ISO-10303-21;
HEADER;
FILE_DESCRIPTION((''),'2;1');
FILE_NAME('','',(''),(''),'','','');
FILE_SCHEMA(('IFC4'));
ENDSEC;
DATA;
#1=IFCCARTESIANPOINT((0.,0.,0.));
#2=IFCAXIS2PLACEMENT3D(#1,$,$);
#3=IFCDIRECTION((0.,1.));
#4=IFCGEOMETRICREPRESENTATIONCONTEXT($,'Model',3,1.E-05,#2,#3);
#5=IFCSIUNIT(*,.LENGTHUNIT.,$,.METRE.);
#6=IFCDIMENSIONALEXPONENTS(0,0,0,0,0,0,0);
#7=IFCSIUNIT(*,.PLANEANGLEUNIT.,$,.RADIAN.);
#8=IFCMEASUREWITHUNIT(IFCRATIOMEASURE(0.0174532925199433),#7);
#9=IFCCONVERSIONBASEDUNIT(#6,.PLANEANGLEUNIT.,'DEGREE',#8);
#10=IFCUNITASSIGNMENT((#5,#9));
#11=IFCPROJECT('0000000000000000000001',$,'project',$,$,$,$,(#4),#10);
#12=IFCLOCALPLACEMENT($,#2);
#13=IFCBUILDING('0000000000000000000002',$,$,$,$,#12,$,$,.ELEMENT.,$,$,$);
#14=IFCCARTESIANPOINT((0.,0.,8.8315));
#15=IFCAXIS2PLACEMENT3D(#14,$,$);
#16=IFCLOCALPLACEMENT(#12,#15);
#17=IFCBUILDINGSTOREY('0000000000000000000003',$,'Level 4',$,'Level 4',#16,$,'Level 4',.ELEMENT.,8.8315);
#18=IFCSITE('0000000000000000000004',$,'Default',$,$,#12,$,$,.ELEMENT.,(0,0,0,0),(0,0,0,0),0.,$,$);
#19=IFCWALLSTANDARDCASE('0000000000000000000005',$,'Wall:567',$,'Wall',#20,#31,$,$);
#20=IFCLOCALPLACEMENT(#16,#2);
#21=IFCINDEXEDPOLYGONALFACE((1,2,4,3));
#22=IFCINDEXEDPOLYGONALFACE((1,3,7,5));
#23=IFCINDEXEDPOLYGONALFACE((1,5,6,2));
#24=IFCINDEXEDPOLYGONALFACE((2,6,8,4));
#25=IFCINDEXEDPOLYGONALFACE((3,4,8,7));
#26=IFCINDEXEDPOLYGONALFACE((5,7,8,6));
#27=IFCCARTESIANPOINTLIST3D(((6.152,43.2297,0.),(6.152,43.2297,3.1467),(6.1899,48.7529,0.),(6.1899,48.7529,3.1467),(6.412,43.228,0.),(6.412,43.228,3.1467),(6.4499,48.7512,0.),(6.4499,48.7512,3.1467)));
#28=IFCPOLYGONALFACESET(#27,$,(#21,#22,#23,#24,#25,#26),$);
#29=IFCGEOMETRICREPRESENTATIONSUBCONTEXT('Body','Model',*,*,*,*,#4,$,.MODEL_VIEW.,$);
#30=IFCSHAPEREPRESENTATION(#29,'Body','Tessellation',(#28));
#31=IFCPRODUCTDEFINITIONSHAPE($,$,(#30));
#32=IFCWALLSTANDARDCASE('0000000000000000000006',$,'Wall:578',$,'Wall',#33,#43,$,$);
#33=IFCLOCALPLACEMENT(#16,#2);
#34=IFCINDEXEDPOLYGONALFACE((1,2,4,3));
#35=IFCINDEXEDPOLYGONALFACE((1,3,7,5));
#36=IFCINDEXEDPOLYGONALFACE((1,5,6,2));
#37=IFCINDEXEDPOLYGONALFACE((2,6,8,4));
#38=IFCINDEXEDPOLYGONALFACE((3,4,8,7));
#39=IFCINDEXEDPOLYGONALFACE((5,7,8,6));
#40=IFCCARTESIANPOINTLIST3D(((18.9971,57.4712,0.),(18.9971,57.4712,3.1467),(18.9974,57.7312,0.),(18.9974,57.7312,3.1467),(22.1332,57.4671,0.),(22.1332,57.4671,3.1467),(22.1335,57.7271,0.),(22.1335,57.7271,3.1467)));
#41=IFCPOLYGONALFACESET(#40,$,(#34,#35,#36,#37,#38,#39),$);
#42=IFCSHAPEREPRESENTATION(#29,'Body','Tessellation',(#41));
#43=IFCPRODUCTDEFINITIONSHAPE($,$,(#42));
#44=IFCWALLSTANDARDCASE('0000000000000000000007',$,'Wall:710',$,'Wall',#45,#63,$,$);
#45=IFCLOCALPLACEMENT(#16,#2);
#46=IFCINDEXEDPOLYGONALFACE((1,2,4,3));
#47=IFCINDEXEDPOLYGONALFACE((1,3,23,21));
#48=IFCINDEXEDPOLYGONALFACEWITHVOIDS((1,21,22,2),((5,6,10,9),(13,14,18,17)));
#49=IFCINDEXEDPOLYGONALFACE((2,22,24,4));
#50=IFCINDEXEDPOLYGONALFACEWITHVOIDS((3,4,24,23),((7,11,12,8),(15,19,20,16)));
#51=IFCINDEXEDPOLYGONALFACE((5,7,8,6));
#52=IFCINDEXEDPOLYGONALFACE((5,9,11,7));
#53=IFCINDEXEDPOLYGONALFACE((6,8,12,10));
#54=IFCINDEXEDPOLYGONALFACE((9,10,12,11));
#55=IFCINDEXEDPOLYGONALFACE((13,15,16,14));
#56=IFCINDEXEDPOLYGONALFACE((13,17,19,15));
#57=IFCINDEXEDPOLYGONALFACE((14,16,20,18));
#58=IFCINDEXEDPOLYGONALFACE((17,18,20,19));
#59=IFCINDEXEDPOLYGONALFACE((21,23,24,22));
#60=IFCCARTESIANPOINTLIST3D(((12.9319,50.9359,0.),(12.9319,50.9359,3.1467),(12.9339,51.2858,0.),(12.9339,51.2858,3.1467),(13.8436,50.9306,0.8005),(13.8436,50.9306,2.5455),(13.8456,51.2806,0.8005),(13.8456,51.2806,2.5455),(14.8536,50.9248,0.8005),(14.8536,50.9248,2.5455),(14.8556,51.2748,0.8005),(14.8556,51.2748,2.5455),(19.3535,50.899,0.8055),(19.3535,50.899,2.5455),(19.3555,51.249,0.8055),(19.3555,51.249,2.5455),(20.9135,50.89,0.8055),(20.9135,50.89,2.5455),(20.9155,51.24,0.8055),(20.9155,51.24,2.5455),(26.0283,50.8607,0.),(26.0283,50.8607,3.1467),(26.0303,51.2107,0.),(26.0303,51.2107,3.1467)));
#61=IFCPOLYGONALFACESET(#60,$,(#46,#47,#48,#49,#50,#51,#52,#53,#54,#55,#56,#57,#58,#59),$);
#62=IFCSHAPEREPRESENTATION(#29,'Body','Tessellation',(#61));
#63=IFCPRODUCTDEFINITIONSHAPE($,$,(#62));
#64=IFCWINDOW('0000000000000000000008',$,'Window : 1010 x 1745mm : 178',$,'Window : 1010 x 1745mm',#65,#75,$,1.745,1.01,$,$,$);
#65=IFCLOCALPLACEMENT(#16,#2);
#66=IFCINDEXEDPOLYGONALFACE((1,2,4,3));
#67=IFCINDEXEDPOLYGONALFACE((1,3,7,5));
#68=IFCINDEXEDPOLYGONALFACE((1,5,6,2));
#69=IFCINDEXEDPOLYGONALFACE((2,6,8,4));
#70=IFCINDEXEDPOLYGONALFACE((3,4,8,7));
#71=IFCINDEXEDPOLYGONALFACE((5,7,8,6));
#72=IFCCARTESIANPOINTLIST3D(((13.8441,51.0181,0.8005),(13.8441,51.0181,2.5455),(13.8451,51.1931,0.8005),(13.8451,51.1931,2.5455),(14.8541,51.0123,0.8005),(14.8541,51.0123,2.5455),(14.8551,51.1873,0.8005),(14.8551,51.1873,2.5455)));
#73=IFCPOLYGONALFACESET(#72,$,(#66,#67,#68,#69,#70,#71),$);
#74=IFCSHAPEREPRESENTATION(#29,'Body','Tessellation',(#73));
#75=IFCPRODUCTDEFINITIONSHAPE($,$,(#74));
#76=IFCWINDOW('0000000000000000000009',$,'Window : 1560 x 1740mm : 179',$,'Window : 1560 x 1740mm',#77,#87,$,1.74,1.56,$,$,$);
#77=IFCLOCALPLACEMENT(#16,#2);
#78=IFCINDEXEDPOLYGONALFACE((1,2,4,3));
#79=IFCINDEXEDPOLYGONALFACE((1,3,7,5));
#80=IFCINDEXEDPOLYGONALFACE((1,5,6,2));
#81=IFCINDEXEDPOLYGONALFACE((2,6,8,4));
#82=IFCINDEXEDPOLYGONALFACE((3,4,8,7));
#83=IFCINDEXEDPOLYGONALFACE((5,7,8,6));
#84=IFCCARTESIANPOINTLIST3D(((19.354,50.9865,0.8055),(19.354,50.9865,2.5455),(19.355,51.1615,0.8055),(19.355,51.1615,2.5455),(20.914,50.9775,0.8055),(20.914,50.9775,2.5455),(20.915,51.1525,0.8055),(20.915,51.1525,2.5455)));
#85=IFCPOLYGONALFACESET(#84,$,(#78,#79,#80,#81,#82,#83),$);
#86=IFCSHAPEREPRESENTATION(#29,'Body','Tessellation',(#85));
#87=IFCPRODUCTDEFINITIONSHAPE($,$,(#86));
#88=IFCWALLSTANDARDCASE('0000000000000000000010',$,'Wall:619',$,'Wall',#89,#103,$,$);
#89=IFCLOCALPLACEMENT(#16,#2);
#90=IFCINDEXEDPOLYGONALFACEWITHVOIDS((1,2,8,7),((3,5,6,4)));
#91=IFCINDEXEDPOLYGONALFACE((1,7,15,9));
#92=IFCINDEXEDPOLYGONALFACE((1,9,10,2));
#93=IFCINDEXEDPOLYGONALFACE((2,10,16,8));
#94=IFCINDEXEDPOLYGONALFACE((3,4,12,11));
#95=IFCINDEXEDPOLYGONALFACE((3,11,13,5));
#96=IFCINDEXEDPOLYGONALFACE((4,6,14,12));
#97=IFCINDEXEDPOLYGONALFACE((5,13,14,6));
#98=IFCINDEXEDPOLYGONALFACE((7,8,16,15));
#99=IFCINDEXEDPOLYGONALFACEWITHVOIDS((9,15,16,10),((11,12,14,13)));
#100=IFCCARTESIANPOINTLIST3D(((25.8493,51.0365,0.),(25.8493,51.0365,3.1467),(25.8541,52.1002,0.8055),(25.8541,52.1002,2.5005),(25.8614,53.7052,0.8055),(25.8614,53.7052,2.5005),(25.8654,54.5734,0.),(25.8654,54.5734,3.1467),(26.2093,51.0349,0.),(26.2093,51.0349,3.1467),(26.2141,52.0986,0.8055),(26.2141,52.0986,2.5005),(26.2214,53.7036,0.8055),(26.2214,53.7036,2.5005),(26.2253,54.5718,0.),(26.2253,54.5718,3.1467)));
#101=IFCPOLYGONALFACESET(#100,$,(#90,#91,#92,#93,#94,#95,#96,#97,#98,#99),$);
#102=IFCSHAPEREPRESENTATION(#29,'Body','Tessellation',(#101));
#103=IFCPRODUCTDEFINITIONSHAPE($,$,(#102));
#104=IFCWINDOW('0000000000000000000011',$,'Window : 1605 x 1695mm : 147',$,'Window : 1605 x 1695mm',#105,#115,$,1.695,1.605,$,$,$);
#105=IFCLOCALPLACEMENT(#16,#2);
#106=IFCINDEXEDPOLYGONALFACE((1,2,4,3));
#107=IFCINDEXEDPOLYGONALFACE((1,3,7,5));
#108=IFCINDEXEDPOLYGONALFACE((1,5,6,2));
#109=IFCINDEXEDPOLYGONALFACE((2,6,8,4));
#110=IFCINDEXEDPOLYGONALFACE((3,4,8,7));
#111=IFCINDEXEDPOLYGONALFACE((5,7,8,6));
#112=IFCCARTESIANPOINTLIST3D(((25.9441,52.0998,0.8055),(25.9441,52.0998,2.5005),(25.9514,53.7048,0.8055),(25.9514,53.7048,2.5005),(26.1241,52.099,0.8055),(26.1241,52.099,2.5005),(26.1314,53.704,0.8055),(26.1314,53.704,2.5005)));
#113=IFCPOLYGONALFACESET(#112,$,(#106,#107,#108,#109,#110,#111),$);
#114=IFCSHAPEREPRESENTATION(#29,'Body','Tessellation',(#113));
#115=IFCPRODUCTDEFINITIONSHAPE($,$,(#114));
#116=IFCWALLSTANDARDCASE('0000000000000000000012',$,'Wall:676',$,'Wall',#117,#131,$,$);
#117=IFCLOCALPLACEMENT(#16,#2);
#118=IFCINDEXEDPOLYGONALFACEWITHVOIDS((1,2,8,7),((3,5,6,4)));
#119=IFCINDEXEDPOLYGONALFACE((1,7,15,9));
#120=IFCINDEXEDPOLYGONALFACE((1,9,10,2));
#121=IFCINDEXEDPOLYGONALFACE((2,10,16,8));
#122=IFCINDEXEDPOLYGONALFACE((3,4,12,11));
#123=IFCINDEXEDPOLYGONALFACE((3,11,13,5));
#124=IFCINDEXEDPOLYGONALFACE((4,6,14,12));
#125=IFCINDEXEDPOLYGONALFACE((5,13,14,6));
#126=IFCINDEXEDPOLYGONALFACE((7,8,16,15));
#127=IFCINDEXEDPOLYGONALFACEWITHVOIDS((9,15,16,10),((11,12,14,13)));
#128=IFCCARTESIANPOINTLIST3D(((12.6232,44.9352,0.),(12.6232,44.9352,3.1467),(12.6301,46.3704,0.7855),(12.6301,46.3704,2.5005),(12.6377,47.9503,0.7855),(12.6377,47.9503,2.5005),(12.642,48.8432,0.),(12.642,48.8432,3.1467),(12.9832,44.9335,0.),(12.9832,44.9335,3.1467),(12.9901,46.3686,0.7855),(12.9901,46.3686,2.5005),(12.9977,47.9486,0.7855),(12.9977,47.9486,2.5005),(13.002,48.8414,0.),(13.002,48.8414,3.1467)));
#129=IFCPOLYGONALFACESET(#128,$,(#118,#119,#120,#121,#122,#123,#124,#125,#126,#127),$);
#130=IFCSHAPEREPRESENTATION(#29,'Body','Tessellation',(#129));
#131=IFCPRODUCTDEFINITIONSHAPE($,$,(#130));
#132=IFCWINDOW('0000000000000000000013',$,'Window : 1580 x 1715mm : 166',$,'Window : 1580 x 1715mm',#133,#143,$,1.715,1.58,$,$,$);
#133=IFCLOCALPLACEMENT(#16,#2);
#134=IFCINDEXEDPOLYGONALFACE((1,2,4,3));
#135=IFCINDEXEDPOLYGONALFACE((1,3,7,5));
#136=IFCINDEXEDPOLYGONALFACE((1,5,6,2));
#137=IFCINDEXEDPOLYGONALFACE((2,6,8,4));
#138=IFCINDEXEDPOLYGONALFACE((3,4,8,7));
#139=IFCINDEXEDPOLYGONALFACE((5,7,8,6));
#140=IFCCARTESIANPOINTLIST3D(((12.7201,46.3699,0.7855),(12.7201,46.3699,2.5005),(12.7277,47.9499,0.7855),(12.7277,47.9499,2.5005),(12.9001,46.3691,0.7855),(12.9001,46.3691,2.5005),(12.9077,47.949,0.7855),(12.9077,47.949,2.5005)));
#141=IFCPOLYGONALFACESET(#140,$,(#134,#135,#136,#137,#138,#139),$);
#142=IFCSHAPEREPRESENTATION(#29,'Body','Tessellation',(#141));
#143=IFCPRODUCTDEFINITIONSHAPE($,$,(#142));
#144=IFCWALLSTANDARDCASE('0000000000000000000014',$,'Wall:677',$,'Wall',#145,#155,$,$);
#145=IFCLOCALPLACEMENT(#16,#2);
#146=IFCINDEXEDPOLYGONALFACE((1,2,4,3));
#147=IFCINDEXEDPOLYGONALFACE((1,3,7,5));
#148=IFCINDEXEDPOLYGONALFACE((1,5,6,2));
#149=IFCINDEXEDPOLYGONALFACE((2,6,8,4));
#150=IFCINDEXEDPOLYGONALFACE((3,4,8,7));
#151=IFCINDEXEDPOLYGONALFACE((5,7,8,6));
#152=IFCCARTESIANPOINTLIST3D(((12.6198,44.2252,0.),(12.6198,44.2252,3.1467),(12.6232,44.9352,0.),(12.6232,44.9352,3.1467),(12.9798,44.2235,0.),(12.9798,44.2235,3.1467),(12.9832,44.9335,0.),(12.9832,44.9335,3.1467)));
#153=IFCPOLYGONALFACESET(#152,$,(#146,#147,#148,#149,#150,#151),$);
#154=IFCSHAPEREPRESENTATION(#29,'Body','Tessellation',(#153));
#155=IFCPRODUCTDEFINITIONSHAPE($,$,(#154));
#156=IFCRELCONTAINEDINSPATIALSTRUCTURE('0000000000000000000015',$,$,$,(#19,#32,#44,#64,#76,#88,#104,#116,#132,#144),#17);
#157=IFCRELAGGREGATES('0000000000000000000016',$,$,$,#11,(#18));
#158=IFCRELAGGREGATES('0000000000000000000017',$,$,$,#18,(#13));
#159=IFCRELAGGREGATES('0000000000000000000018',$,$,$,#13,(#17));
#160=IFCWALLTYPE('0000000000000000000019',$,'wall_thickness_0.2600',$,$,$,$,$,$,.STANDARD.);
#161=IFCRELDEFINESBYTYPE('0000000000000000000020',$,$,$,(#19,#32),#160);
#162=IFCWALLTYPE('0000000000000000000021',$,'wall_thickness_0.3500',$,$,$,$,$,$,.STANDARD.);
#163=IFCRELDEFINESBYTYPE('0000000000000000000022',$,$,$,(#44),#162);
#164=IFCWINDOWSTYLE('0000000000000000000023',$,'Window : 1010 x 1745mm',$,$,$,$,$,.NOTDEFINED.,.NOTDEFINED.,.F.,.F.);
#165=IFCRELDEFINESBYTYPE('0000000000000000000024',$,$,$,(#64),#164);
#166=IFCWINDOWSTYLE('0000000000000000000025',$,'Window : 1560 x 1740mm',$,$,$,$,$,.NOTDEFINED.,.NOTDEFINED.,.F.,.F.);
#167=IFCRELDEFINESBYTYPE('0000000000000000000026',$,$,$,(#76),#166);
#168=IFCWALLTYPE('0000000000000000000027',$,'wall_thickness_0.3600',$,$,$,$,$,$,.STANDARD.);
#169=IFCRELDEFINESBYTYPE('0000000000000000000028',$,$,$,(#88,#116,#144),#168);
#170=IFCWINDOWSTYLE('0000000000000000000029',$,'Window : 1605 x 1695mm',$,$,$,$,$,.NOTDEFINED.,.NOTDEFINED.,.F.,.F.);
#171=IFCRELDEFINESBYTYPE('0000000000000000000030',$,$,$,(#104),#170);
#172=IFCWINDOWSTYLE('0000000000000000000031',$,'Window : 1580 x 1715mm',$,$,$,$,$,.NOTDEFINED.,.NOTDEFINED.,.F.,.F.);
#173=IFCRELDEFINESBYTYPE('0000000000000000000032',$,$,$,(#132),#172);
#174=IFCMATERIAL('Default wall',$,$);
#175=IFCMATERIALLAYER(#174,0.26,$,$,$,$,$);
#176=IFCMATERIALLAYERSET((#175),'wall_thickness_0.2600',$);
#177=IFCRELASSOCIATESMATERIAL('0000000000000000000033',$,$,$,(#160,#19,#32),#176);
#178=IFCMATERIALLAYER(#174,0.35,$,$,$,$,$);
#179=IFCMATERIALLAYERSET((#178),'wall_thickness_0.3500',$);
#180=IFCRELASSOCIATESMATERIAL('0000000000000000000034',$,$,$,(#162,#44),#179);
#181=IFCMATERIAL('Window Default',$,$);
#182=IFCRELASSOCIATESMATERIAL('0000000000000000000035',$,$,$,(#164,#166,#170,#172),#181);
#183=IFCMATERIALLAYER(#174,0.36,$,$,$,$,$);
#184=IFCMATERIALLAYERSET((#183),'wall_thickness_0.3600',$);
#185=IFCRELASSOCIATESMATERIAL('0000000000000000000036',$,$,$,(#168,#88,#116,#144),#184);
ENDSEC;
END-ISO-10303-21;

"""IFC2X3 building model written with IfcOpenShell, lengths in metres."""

from ifc_helpers import new_model, entity, si_unit, converted_unit, direction, frame, frame_2d, origin, origin_2d_with_axis, place, context, subcontext, project, spatial, polyline, rectangle, outline, extrude, source, transform, mapped, material, layer, layer_set, layer_usage, type_object, type_shapes, element, fill, save


model = new_model("IFC2X3")

# Units and contexts
model_context = context("Model", 3, precision=1e-05, world=origin(), true_north=direction((0.0, 1.0)))
body_context = subcontext(model_context, "Body", "Model", "MODEL_VIEW")
ifc_project = project(units=[si_unit("LENGTHUNIT", "METRE"), converted_unit("PLANEANGLEUNIT", "DEGREE", entity("IfcRatioMeasure", 0.0174532925199433), si_unit("PLANEANGLEUNIT", "RADIAN"), dimensions=[0, 0, 0, 0, 0, 0, 0])], contexts=[model_context])

# Site, building, storey
placement_1 = place(None, origin())
site = spatial("IfcSite", under=ifc_project, at=placement_1, Name="Default", CompositionType="ELEMENT", RefLatitude=(0, 0, 0, 0), RefLongitude=(0, 0, 0, 0), RefElevation=0.0)
building = spatial("IfcBuilding", under=site, at=placement_1, CompositionType="ELEMENT")
storey_placement = place(placement_1, frame((0.0, 0.0, 8.8315)))
storey = spatial("IfcBuildingStorey", under=building, at=storey_placement, Name="Level 4", ObjectType="Level 4", LongName="Level 4", CompositionType="ELEMENT", Elevation=8.8315)

# Walls
ifc_material_1 = material(Name="Default wall")
ifc_layer_1 = layer(ifc_material_1, 0.26)
ifc_layer_set_1 = layer_set([ifc_layer_1], Name="wall_thickness_0.2600")
ifc_layer_usage_1 = layer_usage(ifc_layer_set_1, "AXIS2", "POSITIVE", -0.13)
wall_type_1 = type_object("IfcWallType", Name="wall_thickness_0.2600", PredefinedType="STANDARD", material=ifc_layer_set_1)
wall_1_placement = place(storey_placement, frame((6.3199, 48.7521, 0.0), z_axis=(0.0, 0.0, 1.0), x_axis=(-0.006862, -0.999976, 0.0)))
element("IfcWallStandardCase", 1, at=wall_1_placement, inside=storey, type_object=wall_type_1, material=ifc_layer_usage_1, Name="Wall:567", ObjectType="Wall", context=body_context, shape_type="SweptSolid", body=[
    extrude(outline(polyline([(5.5233, -0.13), (5.5233, 0.13), (0.0, 0.13), (0.0, -0.13), (5.5233, -0.13)])), origin(), (0.0, 0.0, 1.0), 3.1467),
])
wall_2_placement = place(storey_placement, frame((18.9973, 57.6012, 0.0), z_axis=(0.0, 0.0, 1.0), x_axis=(0.999999, -0.001299, 0.0)))
element("IfcWallStandardCase", 2, at=wall_2_placement, inside=storey, type_object=wall_type_1, material=ifc_layer_usage_1, Name="Wall:578", ObjectType="Wall", context=body_context, shape_type="SweptSolid", body=[
    extrude(outline(polyline([(3.1361, -0.13), (3.1361, 0.13), (0.0, 0.13), (0.0, -0.13), (3.1361, -0.13)])), origin(), (0.0, 0.0, 1.0), 3.1467),
])

# Wall, openings, windows
ifc_layer_2 = layer(ifc_material_1, 0.35)
ifc_layer_set_2 = layer_set([ifc_layer_2], Name="wall_thickness_0.3500")
ifc_layer_usage_2 = layer_usage(ifc_layer_set_2, "AXIS2", "POSITIVE", -0.175)
wall_type_2 = type_object("IfcWallType", Name="wall_thickness_0.3500", PredefinedType="STANDARD", material=ifc_layer_set_2)
wall_3_placement = place(storey_placement, frame((12.9329, 51.1108, 0.0), z_axis=(0.0, 0.0, 1.0), x_axis=(0.999984, -0.00574, 0.0)))
wall_3 = element("IfcWallStandardCase", 3, at=wall_3_placement, inside=storey, type_object=wall_type_2, material=ifc_layer_usage_2, Name="Wall:710", ObjectType="Wall", context=body_context, shape_type="SweptSolid", body=[
    extrude(outline(polyline([(13.0966, -0.175), (13.0966, 0.175), (0.0, 0.175), (0.0, -0.175), (13.0966, -0.175)])), origin(), (0.0, 0.0, 1.0), 3.1467),
])
opening_1_placement = place(wall_3_placement, frame((0.9117, -0.175, 0.8005)))
opening_1 = element("IfcOpeningElement", 4, at=opening_1_placement, cuts=wall_3, ObjectType="Opening", context=body_context, shape_type="SweptSolid", body=[
    extrude(rectangle(XDim=1.01, YDim=1.745, at=frame_2d((0.8725, 0.505), x_axis=(0.0, 1.0))), frame((0.0, 0.0, 0.0), z_axis=(0.0, 1.0, 0.0), x_axis=(0.0, 0.0, 1.0)), (0.0, 0.0, 1.0), 0.35),
])
opening_2_placement = place(wall_3_placement, frame((6.4217, -0.175, 0.8055)))
opening_2 = element("IfcOpeningElement", 5, at=opening_2_placement, cuts=wall_3, ObjectType="Opening", context=body_context, shape_type="SweptSolid", body=[
    extrude(rectangle(XDim=1.56, YDim=1.74, at=frame_2d((0.87, 0.78), x_axis=(0.0, 1.0))), frame((0.0, 0.0, 0.0), z_axis=(0.0, 1.0, 0.0), x_axis=(0.0, 0.0, 1.0)), (0.0, 0.0, 1.0), 0.35),
])
ifc_material_2 = material(Name="Window Default")
window_style_1 = type_object("IfcWindowStyle", Name="Window : 1010 x 1745mm", ConstructionType="NOTDEFINED", OperationType="NOTDEFINED", ParameterTakesPrecedence=False, Sizeable=False, material=ifc_material_2)
shared_shape_1 = source(origin(), body_context, "Body", "SweptSolid", [
    extrude(rectangle(XDim=0.175, YDim=1.01, at=origin_2d_with_axis()), frame((0.505, 0.175, 0.0), z_axis=(0.0, 0.0, 1.0), x_axis=(0.0, 1.0, 0.0)), (0.0, 0.0, 1.0), 1.745),
])
type_shapes(window_style_1, [shared_shape_1])
window_1_placement = place(opening_1_placement, origin())
window_1 = element("IfcWindow", 6, at=window_1_placement, inside=storey, type_object=window_style_1, Name="Window : 1010 x 1745mm : 178", ObjectType="Window : 1010 x 1745mm", OverallHeight=1.745, OverallWidth=1.01, context=body_context, shape_type="MappedRepresentation", body=[
    mapped(shared_shape_1, transform((0.0, 0.0, 0.0), scale=1.0)),
])
fill(opening_1, window_1)
window_style_2 = type_object("IfcWindowStyle", Name="Window : 1560 x 1740mm", ConstructionType="NOTDEFINED", OperationType="NOTDEFINED", ParameterTakesPrecedence=False, Sizeable=False, material=ifc_material_2)
shared_shape_2 = source(origin(), body_context, "Body", "SweptSolid", [
    extrude(rectangle(XDim=0.175, YDim=1.56, at=origin_2d_with_axis()), frame((0.78, 0.175, 0.0), z_axis=(0.0, 0.0, 1.0), x_axis=(0.0, 1.0, 0.0)), (0.0, 0.0, 1.0), 1.74),
])
type_shapes(window_style_2, [shared_shape_2])
window_2_placement = place(opening_2_placement, origin())
window_2 = element("IfcWindow", 7, at=window_2_placement, inside=storey, type_object=window_style_2, Name="Window : 1560 x 1740mm : 179", ObjectType="Window : 1560 x 1740mm", OverallHeight=1.74, OverallWidth=1.56, context=body_context, shape_type="MappedRepresentation", body=[
    mapped(shared_shape_2, transform((0.0, 0.0, 0.0), scale=1.0)),
])
fill(opening_2, window_2)

# Walls, openings, windows
ifc_layer_3 = layer(ifc_material_1, 0.36)
ifc_layer_set_3 = layer_set([ifc_layer_3], Name="wall_thickness_0.3600")
ifc_layer_usage_3 = layer_usage(ifc_layer_set_3, "AXIS2", "POSITIVE", -0.18)
wall_type_3 = type_object("IfcWallType", Name="wall_thickness_0.3600", PredefinedType="STANDARD", material=ifc_layer_set_3)
wall_4_placement = place(storey_placement, frame((26.0453, 54.5726, 0.0), z_axis=(0.0, 0.0, 1.0), x_axis=(-0.004551, -0.99999, 0.0)))
wall_4 = element("IfcWallStandardCase", 8, at=wall_4_placement, inside=storey, type_object=wall_type_3, material=ifc_layer_usage_3, Name="Wall:619", ObjectType="Wall", context=body_context, shape_type="SweptSolid", body=[
    extrude(outline(polyline([(3.537, -0.18), (3.537, 0.18), (0.0, 0.18), (0.0, -0.18), (3.537, -0.18)])), origin(), (0.0, 0.0, 1.0), 3.1467),
])
opening_3_placement = place(wall_4_placement, frame((0.8683, -0.18, 0.8055)))
opening_3 = element("IfcOpeningElement", 9, at=opening_3_placement, cuts=wall_4, ObjectType="Opening", context=body_context, shape_type="SweptSolid", body=[
    extrude(rectangle(XDim=1.605, YDim=1.695, at=frame_2d((0.8475, 0.8025), x_axis=(0.0, 1.0))), frame((0.0, 0.0, 0.0), z_axis=(0.0, 1.0, 0.0), x_axis=(0.0, 0.0, 1.0)), (0.0, 0.0, 1.0), 0.36),
])
window_style_3 = type_object("IfcWindowStyle", Name="Window : 1605 x 1695mm", ConstructionType="NOTDEFINED", OperationType="NOTDEFINED", ParameterTakesPrecedence=False, Sizeable=False, material=ifc_material_2)
shared_shape_3 = source(origin(), body_context, "Body", "SweptSolid", [
    extrude(rectangle(XDim=0.18, YDim=1.605, at=origin_2d_with_axis()), frame((0.8025, 0.18, 0.0), z_axis=(0.0, 0.0, 1.0), x_axis=(0.0, 1.0, 0.0)), (0.0, 0.0, 1.0), 1.695),
])
type_shapes(window_style_3, [shared_shape_3])
window_3_placement = place(opening_3_placement, origin())
window_3 = element("IfcWindow", 10, at=window_3_placement, inside=storey, type_object=window_style_3, Name="Window : 1605 x 1695mm : 147", ObjectType="Window : 1605 x 1695mm", OverallHeight=1.695, OverallWidth=1.605, context=body_context, shape_type="MappedRepresentation", body=[
    mapped(shared_shape_3, transform((0.0, 0.0, 0.0), scale=1.0)),
])
fill(opening_3, window_3)
wall_5_placement = place(storey_placement, frame((12.822, 48.8423, 0.0), z_axis=(0.0, 0.0, 1.0), x_axis=(-0.004801, -0.999988, 0.0)))
wall_5 = element("IfcWallStandardCase", 11, at=wall_5_placement, inside=storey, type_object=wall_type_3, material=ifc_layer_usage_3, Name="Wall:676", ObjectType="Wall", context=body_context, shape_type="SweptSolid", body=[
    extrude(outline(polyline([(3.908, -0.18), (3.908, 0.18), (0.0, 0.18), (0.0, -0.18), (3.908, -0.18)])), origin(), (0.0, 0.0, 1.0), 3.1467),
])
opening_4_placement = place(wall_5_placement, frame((0.8929, -0.18, 0.7855)))
opening_4 = element("IfcOpeningElement", 12, at=opening_4_placement, cuts=wall_5, ObjectType="Opening", context=body_context, shape_type="SweptSolid", body=[
    extrude(rectangle(XDim=1.58, YDim=1.715, at=frame_2d((0.8575, 0.79), x_axis=(0.0, 1.0))), frame((0.0, 0.0, 0.0), z_axis=(0.0, 1.0, 0.0), x_axis=(0.0, 0.0, 1.0)), (0.0, 0.0, 1.0), 0.36),
])
window_style_4 = type_object("IfcWindowStyle", Name="Window : 1580 x 1715mm", ConstructionType="NOTDEFINED", OperationType="NOTDEFINED", ParameterTakesPrecedence=False, Sizeable=False, material=ifc_material_2)
shared_shape_4 = source(origin(), body_context, "Body", "SweptSolid", [
    extrude(rectangle(XDim=0.18, YDim=1.58, at=origin_2d_with_axis()), frame((0.79, 0.18, 0.0), z_axis=(0.0, 0.0, 1.0), x_axis=(0.0, 1.0, 0.0)), (0.0, 0.0, 1.0), 1.715),
])
type_shapes(window_style_4, [shared_shape_4])
window_4_placement = place(opening_4_placement, origin())
window_4 = element("IfcWindow", 13, at=window_4_placement, inside=storey, type_object=window_style_4, Name="Window : 1580 x 1715mm : 166", ObjectType="Window : 1580 x 1715mm", OverallHeight=1.715, OverallWidth=1.58, context=body_context, shape_type="MappedRepresentation", body=[
    mapped(shared_shape_4, transform((0.0, 0.0, 0.0), scale=1.0)),
])
fill(opening_4, window_4)

# Wall
wall_6_placement = place(storey_placement, frame((12.8032, 44.9343, 0.0), z_axis=(0.0, 0.0, 1.0), x_axis=(-0.004801, -0.999988, 0.0)))
element("IfcWallStandardCase", 14, at=wall_6_placement, inside=storey, type_object=wall_type_3, material=ifc_layer_usage_3, Name="Wall:677", ObjectType="Wall", context=body_context, shape_type="SweptSolid", body=[
    extrude(outline(polyline([(0.71, -0.18), (0.71, 0.18), (0.0, 0.18), (0.0, -0.18), (0.71, -0.18)])), origin(), (0.0, 0.0, 1.0), 3.1467),
])

save(model, "model.ifc")
